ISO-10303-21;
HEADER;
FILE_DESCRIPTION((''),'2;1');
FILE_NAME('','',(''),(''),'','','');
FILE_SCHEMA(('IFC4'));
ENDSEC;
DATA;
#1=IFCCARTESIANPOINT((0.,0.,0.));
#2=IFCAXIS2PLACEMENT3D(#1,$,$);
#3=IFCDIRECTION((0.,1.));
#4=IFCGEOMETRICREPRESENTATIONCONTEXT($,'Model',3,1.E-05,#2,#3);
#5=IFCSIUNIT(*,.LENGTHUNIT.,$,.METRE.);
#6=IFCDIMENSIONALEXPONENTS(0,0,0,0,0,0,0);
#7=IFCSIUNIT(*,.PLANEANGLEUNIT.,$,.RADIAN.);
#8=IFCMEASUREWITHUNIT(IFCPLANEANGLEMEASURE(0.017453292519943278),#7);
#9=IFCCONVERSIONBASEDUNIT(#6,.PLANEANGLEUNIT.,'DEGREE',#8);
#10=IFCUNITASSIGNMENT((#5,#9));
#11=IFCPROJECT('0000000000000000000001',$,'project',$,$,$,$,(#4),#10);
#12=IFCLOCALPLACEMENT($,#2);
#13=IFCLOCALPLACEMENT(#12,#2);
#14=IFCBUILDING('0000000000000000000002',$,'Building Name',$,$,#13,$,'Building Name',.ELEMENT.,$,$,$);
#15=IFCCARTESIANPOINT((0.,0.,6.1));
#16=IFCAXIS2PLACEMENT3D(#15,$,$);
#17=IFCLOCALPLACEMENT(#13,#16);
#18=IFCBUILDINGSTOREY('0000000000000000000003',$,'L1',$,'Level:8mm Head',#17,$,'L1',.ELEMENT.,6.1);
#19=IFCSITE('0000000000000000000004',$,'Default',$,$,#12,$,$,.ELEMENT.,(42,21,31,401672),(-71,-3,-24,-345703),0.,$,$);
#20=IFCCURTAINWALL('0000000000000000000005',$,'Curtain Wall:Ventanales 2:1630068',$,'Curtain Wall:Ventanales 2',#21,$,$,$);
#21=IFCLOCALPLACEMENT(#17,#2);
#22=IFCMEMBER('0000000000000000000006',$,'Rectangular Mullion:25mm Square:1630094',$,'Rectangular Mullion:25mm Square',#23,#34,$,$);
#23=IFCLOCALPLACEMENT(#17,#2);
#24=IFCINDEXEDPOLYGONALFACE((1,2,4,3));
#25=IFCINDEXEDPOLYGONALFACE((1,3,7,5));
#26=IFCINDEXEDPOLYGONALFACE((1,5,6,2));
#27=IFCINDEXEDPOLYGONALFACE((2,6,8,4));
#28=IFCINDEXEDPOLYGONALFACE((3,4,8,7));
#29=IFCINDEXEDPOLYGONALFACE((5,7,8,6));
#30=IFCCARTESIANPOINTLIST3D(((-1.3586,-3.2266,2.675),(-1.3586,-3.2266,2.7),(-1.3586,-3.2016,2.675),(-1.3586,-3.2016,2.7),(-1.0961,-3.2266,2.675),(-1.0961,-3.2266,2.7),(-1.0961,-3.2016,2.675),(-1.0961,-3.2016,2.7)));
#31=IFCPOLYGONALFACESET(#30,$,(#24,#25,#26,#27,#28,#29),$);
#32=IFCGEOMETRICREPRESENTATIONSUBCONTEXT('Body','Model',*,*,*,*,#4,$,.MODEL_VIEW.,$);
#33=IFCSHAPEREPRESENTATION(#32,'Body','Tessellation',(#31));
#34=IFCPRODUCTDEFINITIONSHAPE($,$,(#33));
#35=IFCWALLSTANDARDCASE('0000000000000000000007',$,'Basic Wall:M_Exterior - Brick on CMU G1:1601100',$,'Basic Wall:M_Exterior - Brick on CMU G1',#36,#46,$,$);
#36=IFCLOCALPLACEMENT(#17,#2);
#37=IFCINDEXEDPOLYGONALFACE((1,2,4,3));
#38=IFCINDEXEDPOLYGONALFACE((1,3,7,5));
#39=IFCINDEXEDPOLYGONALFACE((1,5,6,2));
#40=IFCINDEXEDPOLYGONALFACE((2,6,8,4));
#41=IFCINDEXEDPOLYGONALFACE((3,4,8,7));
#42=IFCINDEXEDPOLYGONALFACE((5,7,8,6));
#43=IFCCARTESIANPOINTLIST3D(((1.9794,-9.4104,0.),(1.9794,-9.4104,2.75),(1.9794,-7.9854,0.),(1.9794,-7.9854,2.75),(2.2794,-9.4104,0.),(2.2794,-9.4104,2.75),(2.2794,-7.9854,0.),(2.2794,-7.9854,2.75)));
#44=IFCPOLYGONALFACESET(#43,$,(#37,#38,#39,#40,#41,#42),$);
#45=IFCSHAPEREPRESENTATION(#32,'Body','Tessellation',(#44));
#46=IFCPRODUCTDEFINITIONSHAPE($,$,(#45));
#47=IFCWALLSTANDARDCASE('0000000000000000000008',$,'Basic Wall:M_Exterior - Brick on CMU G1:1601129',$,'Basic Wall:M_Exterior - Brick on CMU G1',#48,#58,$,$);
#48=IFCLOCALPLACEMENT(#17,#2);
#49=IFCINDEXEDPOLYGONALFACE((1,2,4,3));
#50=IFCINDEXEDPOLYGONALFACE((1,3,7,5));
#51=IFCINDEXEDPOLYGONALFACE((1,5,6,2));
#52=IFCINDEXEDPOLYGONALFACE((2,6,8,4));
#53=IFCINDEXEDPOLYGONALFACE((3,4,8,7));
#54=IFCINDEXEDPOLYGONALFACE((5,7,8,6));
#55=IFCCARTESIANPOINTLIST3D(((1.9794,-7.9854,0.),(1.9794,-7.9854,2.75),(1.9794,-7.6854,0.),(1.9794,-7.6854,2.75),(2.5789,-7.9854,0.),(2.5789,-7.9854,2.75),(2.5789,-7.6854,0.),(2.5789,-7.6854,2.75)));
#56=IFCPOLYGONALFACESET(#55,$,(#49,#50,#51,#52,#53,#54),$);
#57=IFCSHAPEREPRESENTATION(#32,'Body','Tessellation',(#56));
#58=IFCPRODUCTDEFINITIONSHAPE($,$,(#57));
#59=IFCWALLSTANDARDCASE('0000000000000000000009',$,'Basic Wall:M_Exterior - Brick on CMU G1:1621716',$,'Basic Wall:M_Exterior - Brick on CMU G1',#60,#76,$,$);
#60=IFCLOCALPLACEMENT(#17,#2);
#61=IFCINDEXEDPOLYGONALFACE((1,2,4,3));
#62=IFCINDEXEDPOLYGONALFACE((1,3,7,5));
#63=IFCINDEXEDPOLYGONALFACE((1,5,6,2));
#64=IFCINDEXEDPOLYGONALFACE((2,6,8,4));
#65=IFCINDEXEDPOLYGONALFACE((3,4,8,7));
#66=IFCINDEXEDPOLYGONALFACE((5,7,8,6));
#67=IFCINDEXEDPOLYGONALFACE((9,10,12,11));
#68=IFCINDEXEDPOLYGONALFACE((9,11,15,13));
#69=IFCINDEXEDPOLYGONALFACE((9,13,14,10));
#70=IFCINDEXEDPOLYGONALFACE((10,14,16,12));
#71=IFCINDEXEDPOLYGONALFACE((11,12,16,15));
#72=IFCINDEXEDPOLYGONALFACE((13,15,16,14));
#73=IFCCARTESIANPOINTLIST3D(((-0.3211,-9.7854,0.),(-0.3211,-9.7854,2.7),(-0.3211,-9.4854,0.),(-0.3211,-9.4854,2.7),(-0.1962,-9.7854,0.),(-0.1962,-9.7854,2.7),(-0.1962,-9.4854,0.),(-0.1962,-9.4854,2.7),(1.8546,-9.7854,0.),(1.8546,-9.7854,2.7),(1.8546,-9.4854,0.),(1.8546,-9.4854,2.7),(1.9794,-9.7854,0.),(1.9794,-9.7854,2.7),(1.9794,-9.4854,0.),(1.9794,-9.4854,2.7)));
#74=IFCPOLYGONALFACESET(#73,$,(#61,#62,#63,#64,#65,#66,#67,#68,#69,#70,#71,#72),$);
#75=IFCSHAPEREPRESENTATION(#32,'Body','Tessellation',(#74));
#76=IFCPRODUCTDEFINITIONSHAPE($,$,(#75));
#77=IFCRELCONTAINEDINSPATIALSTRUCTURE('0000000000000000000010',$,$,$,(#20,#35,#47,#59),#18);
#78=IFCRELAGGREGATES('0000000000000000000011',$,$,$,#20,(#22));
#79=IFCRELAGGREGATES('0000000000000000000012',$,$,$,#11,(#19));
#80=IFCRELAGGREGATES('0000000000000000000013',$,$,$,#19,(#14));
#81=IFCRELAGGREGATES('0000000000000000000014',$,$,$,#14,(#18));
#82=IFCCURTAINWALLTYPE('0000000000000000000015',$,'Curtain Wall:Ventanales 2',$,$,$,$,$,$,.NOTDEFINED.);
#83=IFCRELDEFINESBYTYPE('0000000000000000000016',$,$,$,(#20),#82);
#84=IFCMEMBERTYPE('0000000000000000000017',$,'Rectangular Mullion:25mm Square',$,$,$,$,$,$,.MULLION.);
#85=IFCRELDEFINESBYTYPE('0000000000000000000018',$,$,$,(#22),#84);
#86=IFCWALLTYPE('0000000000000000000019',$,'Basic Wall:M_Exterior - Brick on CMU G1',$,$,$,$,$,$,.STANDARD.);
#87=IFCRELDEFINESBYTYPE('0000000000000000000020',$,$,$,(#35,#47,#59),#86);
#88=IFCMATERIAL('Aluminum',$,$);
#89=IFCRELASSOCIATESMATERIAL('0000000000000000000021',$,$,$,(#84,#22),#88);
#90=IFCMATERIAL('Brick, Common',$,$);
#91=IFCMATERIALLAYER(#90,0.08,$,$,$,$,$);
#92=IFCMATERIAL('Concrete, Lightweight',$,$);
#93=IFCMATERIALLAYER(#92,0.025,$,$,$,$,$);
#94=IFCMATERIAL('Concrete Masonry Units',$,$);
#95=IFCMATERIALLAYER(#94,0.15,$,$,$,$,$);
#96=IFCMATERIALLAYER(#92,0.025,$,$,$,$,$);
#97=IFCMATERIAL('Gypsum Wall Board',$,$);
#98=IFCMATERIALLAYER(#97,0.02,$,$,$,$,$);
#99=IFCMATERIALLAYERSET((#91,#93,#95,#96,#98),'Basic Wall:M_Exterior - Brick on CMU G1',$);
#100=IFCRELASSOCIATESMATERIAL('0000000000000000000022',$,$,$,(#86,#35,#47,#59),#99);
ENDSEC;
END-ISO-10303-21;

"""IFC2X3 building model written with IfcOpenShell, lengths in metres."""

from ifc_helpers import new_model, entity, si_unit, converted_unit, direction, frame, frame_2d, origin, origin_2d_with_axis, place, context, subcontext, project, spatial, rectangle, extrude, source, transform, mapped, material, layer, layer_set, layer_usage, type_object, type_shapes, element, aggregate, save


model = new_model("IFC2X3")

# Units and contexts
model_context = context("Model", 3, precision=1e-05, world=origin(), true_north=direction((0.0, 1.0)))
body_context = subcontext(model_context, "Body", "Model", "MODEL_VIEW")
ifc_project = project(units=[si_unit("LENGTHUNIT", "METRE"), converted_unit("PLANEANGLEUNIT", "DEGREE", entity("IfcPlaneAngleMeasure", 0.017453292519943278), si_unit("PLANEANGLEUNIT", "RADIAN"), dimensions=[0, 0, 0, 0, 0, 0, 0])], contexts=[model_context])

# Site, building, storey
site_placement = place(None, origin())
site = spatial("IfcSite", under=ifc_project, at=site_placement, Name="Default", CompositionType="ELEMENT", RefLatitude=(42, 21, 31, 401672), RefLongitude=(-71, -3, -24, -345703), RefElevation=0.0)
building_placement = place(site_placement, origin())
building = spatial("IfcBuilding", under=site, at=building_placement, Name="Building Name", LongName="Building Name", CompositionType="ELEMENT")
storey_placement = place(building_placement, frame((0.0, 0.0, 6.1)))
storey = spatial("IfcBuildingStorey", under=building, at=storey_placement, Name="L1", ObjectType="Level:8mm Head", LongName="L1", CompositionType="ELEMENT", Elevation=6.1)

# Shared definitions
ifc_material_1 = material(Name="Aluminum")

# Curtain wall, member
curtain_wall_type_1 = type_object("IfcCurtainWallType", Name="Curtain Wall:Ventanales 2", PredefinedType="NOTDEFINED")
curtain_wall_1_placement = place(storey_placement, frame((0.0, 0.0, -6.1)))
curtain_wall_1 = element("IfcCurtainWall", 1, at=curtain_wall_1_placement, inside=storey, type_object=curtain_wall_type_1, Name="Curtain Wall:Ventanales 2:1630068", ObjectType="Curtain Wall:Ventanales 2")
member_type_1 = type_object("IfcMemberType", Name="Rectangular Mullion:25mm Square", PredefinedType="MULLION", material=ifc_material_1)
shared_shape_1 = source(origin(), body_context, "Body", "SweptSolid", [
    extrude(rectangle(XDim=0.025, YDim=0.025, at=origin_2d_with_axis()), frame((-0.0125, 0.0, -0.2625), z_axis=(0.0, 0.0, 1.0), x_axis=(-1.0, 0.0, 0.0)), (0.0, 0.0, 1.0), 0.2625),
])
type_shapes(member_type_1, [shared_shape_1])
member_1_placement = place(curtain_wall_1_placement, frame((-1.0961, -3.2141, 8.8), z_axis=(1.0, 0.0, 0.0), x_axis=(0.0, 0.0, 1.0)))
member_1 = element("IfcMember", 2, at=member_1_placement, type_object=member_type_1, material=ifc_material_1, Name="Rectangular Mullion:25mm Square:1630094", ObjectType="Rectangular Mullion:25mm Square", context=body_context, shape_type="MappedRepresentation", body=[
    mapped(shared_shape_1, transform((0.0, 0.0, 0.0), scale=1.0)),
])
aggregate(curtain_wall_1, [member_1])

# Shared definitions
ifc_material_2 = material(Name="Brick, Common")
ifc_layer_1 = layer(ifc_material_2, 0.08)
ifc_material_3 = material(Name="Concrete, Lightweight")
ifc_layer_2 = layer(ifc_material_3, 0.025)
ifc_material_4 = material(Name="Concrete Masonry Units")
ifc_layer_3 = layer(ifc_material_4, 0.15)
ifc_layer_4 = layer(ifc_material_3, 0.025)
ifc_material_5 = material(Name="Gypsum Wall Board")
ifc_layer_5 = layer(ifc_material_5, 0.02)
ifc_layer_set = layer_set([ifc_layer_1, ifc_layer_2, ifc_layer_3, ifc_layer_4, ifc_layer_5], Name="Basic Wall:M_Exterior - Brick on CMU G1")
wall_type = type_object("IfcWallType", Name="Basic Wall:M_Exterior - Brick on CMU G1", PredefinedType="STANDARD", material=ifc_layer_set)

# Walls
ifc_layer_usage_1 = layer_usage(ifc_layer_set, "AXIS2", "POSITIVE", -0.15)
wall_1_placement = place(storey_placement, frame((2.1294, -9.4104, 0.0), z_axis=(0.0, 0.0, 1.0), x_axis=(0.0, 1.0, 0.0)))
element("IfcWallStandardCase", 3, at=wall_1_placement, inside=storey, type_object=wall_type, material=ifc_layer_usage_1, Name="Basic Wall:M_Exterior - Brick on CMU G1:1601100", ObjectType="Basic Wall:M_Exterior - Brick on CMU G1", context=body_context, shape_type="SweptSolid", body=[
    extrude(rectangle(XDim=1.425, YDim=0.3, at=frame_2d((0.7125, 0.0), x_axis=(-1.0, 0.0))), origin(), (0.0, 0.0, 1.0), 2.75),
])
ifc_layer_usage_2 = layer_usage(ifc_layer_set, "AXIS2", "NEGATIVE", 0.15)
wall_2_placement = place(storey_placement, frame((2.5789, -7.8354, 0.0), z_axis=(0.0, 0.0, 1.0), x_axis=(-1.0, 0.0, 0.0)))
element("IfcWallStandardCase", 4, at=wall_2_placement, inside=storey, type_object=wall_type, material=ifc_layer_usage_2, Name="Basic Wall:M_Exterior - Brick on CMU G1:1601129", ObjectType="Basic Wall:M_Exterior - Brick on CMU G1", context=body_context, shape_type="SweptSolid", body=[
    extrude(rectangle(XDim=0.5995, YDim=0.3, at=frame_2d((0.2997, 0.0), x_axis=(-1.0, 0.0))), origin(), (0.0, 0.0, 1.0), 2.75),
])

# Wall, opening
ifc_layer_usage_3 = layer_usage(ifc_layer_set, "AXIS2", "NEGATIVE", 0.15)
wall_3_placement = place(storey_placement, frame((-0.3211, -9.6354, 0.0)))
wall_3 = element("IfcWallStandardCase", 5, at=wall_3_placement, inside=storey, type_object=wall_type, material=ifc_layer_usage_3, Name="Basic Wall:M_Exterior - Brick on CMU G1:1621716", ObjectType="Basic Wall:M_Exterior - Brick on CMU G1", context=body_context, shape_type="SweptSolid", body=[
    extrude(rectangle(XDim=2.3005, YDim=0.3, at=frame_2d((1.1503, 0.0), x_axis=(-1.0, 0.0))), origin(), (0.0, 0.0, 1.0), 2.7),
])
opening_1_placement = place(wall_3_placement, frame((2.1757, 0.15, 0.0)))
element("IfcOpeningElement", 6, at=opening_1_placement, cuts=wall_3, ObjectType="Opening", context=body_context, shape_type="SweptSolid", body=[
    extrude(rectangle(XDim=2.7754, YDim=2.0508, at=frame_2d((1.3877, 1.0254), x_axis=(1.0, 0.0))), frame((0.0, 0.0, 0.0), z_axis=(0.0, -1.0, 0.0), x_axis=(0.0, 0.0, 1.0)), (0.0, 0.0, 1.0), 0.3),
])

save(model, "model.ifc")
